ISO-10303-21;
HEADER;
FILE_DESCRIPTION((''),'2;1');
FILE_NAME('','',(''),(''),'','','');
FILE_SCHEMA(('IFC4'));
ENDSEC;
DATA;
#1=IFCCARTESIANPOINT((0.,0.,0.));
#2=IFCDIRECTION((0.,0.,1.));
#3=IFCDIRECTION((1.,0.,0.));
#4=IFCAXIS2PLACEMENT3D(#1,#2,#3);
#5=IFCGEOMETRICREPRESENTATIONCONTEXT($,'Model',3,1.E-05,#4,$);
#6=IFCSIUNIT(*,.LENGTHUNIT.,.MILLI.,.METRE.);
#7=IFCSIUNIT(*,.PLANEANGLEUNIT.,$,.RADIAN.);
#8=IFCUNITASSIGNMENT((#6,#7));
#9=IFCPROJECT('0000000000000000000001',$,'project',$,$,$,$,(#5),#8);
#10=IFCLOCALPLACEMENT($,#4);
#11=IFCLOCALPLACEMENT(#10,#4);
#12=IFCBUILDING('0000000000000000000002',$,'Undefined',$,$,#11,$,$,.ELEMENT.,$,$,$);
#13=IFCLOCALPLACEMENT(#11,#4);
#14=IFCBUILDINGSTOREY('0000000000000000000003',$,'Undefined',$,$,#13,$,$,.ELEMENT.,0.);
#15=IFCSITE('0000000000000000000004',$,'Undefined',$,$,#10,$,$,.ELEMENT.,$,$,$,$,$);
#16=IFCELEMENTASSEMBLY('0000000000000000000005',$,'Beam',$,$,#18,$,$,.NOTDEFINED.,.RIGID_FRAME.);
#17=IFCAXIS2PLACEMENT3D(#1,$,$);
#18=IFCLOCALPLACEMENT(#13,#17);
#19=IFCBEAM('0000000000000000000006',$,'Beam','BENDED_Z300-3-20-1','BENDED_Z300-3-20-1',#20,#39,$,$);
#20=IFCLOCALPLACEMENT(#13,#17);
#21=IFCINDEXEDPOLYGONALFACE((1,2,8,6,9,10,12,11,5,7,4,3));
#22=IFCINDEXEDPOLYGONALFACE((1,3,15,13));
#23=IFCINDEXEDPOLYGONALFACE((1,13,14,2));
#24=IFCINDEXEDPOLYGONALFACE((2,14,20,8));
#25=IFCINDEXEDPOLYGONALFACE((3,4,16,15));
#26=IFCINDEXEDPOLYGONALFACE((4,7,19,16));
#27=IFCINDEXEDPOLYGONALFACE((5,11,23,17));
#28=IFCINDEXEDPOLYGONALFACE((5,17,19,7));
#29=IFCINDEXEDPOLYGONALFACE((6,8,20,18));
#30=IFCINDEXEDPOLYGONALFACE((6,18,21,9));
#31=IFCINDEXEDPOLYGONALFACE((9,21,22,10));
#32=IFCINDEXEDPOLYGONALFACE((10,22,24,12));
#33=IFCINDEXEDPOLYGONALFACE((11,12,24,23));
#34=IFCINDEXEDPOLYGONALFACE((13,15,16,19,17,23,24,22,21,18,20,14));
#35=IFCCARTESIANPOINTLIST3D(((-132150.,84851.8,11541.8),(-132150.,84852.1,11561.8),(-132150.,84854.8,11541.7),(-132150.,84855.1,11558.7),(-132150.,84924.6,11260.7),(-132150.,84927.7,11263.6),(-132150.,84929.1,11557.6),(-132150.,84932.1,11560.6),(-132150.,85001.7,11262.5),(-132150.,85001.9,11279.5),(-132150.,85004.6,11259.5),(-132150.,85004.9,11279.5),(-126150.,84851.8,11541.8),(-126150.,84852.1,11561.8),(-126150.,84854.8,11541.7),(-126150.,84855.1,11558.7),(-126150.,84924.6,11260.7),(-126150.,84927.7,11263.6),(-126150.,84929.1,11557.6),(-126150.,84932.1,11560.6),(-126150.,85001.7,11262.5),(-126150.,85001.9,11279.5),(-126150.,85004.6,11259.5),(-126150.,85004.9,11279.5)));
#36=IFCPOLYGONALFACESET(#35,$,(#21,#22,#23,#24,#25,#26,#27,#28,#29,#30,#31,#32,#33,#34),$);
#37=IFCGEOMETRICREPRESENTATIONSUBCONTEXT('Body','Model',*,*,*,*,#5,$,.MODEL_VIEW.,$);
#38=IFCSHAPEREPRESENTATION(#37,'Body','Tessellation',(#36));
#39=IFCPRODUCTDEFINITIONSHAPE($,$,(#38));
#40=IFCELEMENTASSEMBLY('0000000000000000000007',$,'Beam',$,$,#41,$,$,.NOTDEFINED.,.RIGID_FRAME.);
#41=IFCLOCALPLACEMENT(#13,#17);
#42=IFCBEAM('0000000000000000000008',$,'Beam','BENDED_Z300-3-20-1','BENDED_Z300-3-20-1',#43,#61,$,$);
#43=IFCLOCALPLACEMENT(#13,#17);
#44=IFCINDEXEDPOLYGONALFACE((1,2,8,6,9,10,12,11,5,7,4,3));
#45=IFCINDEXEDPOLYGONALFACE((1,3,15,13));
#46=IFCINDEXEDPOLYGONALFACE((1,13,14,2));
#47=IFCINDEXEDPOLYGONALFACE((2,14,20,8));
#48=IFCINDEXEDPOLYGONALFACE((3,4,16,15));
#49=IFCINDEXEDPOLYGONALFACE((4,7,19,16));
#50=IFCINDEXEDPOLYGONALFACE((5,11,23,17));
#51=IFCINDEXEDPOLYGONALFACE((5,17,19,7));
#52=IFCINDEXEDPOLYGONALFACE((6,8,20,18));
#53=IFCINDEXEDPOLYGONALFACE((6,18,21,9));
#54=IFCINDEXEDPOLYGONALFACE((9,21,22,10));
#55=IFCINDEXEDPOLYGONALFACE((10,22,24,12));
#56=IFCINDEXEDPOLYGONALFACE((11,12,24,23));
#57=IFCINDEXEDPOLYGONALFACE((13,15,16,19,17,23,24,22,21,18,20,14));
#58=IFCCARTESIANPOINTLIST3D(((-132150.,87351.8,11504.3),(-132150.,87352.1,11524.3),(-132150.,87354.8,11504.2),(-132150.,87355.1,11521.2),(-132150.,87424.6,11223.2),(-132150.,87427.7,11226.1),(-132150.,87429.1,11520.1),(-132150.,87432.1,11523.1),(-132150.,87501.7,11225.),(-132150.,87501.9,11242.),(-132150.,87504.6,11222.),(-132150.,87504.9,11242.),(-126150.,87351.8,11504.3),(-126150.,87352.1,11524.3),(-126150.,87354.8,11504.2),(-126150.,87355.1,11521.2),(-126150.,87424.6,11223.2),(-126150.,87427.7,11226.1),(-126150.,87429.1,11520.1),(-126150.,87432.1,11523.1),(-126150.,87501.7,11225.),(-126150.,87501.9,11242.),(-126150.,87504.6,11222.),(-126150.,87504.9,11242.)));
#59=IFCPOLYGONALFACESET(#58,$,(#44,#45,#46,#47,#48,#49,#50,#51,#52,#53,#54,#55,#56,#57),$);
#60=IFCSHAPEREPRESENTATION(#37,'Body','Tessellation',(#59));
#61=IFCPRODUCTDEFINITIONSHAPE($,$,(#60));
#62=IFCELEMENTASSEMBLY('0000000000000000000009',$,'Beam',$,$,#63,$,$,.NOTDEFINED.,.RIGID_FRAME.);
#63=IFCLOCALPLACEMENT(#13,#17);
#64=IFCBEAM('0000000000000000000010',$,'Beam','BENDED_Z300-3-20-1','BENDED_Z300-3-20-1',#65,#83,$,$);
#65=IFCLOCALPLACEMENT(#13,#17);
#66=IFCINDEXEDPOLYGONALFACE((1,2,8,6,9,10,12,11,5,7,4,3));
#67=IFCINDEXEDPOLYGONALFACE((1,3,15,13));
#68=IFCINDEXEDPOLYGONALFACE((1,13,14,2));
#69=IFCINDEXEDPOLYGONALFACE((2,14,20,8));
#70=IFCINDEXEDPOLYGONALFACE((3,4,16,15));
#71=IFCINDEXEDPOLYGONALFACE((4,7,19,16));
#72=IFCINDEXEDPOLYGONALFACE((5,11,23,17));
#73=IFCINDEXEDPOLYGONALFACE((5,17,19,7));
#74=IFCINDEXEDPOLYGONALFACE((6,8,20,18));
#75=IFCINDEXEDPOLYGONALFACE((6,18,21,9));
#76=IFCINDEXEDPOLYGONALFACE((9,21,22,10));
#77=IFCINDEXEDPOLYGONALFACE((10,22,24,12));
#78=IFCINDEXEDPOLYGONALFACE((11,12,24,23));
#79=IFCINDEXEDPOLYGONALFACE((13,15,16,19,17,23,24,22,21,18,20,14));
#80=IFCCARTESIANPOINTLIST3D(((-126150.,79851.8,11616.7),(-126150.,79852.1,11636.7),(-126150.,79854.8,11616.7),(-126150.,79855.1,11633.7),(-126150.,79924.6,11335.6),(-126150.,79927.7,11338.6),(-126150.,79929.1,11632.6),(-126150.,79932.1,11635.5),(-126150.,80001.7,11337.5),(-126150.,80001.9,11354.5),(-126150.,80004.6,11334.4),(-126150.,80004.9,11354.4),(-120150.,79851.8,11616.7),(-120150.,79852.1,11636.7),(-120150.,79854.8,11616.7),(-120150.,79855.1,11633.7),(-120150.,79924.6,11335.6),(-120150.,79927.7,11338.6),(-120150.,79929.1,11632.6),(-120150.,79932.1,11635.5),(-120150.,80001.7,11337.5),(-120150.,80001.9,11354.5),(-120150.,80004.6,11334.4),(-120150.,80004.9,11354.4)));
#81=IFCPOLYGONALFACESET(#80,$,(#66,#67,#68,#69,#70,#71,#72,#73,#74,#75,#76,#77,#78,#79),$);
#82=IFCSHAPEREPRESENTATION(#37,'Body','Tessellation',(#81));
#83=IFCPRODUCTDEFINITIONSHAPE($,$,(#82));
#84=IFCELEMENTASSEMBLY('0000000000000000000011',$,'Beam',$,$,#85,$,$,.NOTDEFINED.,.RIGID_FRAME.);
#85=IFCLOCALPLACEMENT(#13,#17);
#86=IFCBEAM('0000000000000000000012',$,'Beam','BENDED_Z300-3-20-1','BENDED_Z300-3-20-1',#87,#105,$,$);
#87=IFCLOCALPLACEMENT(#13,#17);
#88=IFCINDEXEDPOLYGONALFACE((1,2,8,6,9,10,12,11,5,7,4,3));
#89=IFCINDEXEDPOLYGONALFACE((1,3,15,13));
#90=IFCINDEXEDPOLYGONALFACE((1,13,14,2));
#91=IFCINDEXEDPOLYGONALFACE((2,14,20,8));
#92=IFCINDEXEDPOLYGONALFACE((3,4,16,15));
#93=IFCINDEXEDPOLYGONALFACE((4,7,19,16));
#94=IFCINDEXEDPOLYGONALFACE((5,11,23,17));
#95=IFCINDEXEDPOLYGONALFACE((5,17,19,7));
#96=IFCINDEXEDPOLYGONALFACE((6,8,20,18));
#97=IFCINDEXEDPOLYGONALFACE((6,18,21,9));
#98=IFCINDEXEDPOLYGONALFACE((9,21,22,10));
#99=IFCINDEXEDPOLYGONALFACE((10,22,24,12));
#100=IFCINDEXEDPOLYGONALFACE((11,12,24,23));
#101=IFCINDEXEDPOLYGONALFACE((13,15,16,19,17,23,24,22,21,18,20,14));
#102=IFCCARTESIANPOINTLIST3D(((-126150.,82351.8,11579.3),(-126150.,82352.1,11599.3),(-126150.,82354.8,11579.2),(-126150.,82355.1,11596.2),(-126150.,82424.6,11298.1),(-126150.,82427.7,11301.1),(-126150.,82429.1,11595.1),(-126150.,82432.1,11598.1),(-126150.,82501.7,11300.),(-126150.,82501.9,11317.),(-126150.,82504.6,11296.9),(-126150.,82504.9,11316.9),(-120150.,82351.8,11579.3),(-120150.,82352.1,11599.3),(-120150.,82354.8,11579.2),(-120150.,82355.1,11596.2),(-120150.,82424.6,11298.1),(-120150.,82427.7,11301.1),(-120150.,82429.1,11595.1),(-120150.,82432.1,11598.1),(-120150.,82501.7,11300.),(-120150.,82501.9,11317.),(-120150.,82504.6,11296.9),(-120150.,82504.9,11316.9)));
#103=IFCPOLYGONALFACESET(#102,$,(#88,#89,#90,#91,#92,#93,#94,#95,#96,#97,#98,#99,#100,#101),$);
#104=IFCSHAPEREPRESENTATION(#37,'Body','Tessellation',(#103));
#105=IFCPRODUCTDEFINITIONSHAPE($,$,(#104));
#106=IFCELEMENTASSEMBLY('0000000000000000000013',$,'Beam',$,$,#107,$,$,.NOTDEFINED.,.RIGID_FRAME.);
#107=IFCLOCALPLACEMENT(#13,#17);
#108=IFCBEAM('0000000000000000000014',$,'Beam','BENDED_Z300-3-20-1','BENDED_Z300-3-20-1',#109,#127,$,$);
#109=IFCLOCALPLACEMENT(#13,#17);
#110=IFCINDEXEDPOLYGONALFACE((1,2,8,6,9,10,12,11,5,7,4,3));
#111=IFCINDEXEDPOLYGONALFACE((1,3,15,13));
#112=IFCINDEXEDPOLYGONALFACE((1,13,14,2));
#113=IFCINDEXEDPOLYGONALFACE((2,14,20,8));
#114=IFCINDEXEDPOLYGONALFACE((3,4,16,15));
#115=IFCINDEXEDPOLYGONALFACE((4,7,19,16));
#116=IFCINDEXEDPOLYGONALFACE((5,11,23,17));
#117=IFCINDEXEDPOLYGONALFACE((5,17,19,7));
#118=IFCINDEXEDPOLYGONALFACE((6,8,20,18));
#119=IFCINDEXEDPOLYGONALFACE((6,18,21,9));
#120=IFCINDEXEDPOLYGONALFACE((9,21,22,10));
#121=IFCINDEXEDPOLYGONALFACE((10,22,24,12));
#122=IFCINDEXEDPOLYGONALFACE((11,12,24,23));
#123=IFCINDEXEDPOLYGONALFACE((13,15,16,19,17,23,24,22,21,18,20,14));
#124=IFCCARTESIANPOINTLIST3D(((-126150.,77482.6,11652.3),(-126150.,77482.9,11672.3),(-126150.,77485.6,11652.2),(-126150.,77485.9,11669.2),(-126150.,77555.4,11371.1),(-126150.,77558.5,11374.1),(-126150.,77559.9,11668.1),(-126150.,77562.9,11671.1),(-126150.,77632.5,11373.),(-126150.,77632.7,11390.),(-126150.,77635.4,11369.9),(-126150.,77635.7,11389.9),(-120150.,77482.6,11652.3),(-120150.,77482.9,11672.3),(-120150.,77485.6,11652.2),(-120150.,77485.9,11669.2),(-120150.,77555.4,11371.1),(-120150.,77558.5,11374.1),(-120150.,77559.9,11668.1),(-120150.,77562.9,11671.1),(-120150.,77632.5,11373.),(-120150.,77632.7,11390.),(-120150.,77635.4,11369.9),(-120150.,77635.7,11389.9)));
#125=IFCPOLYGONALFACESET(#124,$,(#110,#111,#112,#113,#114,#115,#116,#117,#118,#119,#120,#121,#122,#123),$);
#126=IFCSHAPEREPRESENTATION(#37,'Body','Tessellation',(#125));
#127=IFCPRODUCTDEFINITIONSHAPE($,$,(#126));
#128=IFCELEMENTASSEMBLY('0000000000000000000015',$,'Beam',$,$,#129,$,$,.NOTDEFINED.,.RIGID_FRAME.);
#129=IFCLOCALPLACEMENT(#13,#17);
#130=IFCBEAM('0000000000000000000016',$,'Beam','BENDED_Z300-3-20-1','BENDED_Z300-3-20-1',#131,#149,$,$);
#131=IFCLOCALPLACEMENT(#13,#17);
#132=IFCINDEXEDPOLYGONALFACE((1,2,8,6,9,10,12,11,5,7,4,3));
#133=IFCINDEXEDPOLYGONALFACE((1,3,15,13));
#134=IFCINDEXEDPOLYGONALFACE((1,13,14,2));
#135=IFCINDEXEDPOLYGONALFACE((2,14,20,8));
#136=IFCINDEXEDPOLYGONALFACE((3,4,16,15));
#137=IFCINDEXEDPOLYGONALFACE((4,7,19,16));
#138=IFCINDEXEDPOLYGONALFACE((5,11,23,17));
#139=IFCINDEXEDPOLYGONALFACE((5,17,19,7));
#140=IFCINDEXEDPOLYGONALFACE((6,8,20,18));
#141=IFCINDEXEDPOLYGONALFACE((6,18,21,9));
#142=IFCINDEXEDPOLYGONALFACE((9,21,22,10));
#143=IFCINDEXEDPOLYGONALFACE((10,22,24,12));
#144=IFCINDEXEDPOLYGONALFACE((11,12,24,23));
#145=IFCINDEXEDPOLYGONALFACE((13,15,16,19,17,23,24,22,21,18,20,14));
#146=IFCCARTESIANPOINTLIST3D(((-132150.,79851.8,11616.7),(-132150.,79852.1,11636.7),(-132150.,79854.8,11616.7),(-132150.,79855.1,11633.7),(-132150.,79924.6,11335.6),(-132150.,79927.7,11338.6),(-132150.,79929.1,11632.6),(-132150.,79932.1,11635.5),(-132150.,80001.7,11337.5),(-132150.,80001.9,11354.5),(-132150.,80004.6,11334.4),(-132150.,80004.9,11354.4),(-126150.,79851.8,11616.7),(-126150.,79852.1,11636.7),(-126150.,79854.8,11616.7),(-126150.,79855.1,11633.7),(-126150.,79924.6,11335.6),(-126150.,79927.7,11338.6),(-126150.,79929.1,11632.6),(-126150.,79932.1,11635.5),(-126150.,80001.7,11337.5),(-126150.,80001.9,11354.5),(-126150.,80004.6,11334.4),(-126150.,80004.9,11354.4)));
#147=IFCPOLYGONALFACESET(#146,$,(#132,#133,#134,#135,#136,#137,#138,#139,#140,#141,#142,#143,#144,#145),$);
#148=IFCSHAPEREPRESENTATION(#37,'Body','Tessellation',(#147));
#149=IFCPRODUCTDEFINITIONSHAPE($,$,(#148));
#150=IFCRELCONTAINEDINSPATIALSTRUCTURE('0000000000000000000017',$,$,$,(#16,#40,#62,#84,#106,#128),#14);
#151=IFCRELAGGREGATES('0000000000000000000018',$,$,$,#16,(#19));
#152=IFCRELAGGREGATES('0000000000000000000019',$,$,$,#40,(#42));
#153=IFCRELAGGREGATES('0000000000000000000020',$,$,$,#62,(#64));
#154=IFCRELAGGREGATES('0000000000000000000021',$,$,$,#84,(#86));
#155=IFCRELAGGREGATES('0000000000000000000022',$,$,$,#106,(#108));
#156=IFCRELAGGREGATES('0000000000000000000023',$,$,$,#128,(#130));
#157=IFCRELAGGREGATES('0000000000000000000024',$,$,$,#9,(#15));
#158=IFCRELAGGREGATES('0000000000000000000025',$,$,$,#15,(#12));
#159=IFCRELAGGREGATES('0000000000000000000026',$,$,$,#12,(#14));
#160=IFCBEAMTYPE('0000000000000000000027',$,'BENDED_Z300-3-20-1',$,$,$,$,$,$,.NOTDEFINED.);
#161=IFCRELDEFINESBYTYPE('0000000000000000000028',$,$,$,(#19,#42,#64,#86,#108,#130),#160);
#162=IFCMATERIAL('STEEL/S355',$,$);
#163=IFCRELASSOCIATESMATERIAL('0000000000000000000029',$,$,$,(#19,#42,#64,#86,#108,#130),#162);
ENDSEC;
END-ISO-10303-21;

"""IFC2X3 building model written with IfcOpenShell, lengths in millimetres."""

from ifc_helpers import new_model, si_unit, frame, origin_with_axes, place, context, subcontext, project, spatial, polyline, outline, extrude, material, type_object, element, aggregate, save


model = new_model("IFC2X3")

# Units and contexts
model_context = context("Model", 3, precision=1e-05, world=origin_with_axes())
body_context = subcontext(model_context, "Body", "Model", "MODEL_VIEW")
ifc_project = project(units=[si_unit("LENGTHUNIT", "METRE", prefix="MILLI"), si_unit("PLANEANGLEUNIT", "RADIAN")], contexts=[model_context])

# Site, building, storey
site_placement = place(None, origin_with_axes())
site = spatial("IfcSite", under=ifc_project, at=site_placement, Name="Undefined", CompositionType="ELEMENT")
building_placement = place(site_placement, origin_with_axes())
building = spatial("IfcBuilding", under=site, at=building_placement, Name="Undefined", CompositionType="ELEMENT")
storey_placement = place(building_placement, origin_with_axes())
storey = spatial("IfcBuildingStorey", under=building, at=storey_placement, Name="Undefined", CompositionType="ELEMENT", Elevation=0.0)

# Element assemblies, beams
ifc_material_1 = material(Name="STEEL/S355")
beam_type_1 = type_object("IfcBeamType", Name="BENDED_Z300-3-20-1", PredefinedType="NOTDEFINED")
assembly_1_placement = place(storey_placement, origin_with_axes())
assembly_1 = element("IfcElementAssembly", 1, at=assembly_1_placement, inside=storey, Name="Beam", AssemblyPlace="NOTDEFINED", PredefinedType="RIGID_FRAME")
beam_1_placement = place(assembly_1_placement, frame((-132150.0, 84928.4, 11410.6), z_axis=(0.0, 0.014963, 0.999888), x_axis=(1.0, 0.0, 0.0)))
beam_1 = element("IfcBeam", 2, at=beam_1_placement, type_object=beam_type_1, material=ifc_material_1, Name="Beam", Description="BENDED_Z300-3-20-1", ObjectType="BENDED_Z300-3-20-1", context=body_context, shape_type="SweptSolid", body=[
    extrude(outline(polyline([(1.5, -150.0), (-78.5, -150.0), (-78.5, -130.0), (-75.5, -130.0), (-75.5, -147.0), (-1.5, -147.0), (-1.5, 150.0), (78.5, 150.0), (78.5, 130.0), (75.5, 130.0), (75.5, 147.0), (1.5, 147.0), (1.5, -150.0)])), frame((6000.0, 0.0, 0.0), z_axis=(-1.0, 0.0, 0.0), x_axis=(0.0, -1.0, 0.0)), (0.0, 0.0, 1.0), 6000.0),
])
aggregate(assembly_1, [beam_1])
assembly_2_placement = place(storey_placement, origin_with_axes())
assembly_2 = element("IfcElementAssembly", 3, at=assembly_2_placement, inside=storey, Name="Beam", AssemblyPlace="NOTDEFINED", PredefinedType="RIGID_FRAME")
beam_2_placement = place(assembly_2_placement, frame((-132150.0, 87428.4, 11373.1), z_axis=(0.0, 0.014963, 0.999888), x_axis=(1.0, 0.0, 0.0)))
beam_2 = element("IfcBeam", 4, at=beam_2_placement, type_object=beam_type_1, material=ifc_material_1, Name="Beam", Description="BENDED_Z300-3-20-1", ObjectType="BENDED_Z300-3-20-1", context=body_context, shape_type="SweptSolid", body=[
    extrude(outline(polyline([(1.5, -150.0), (-78.5, -150.0), (-78.5, -130.0), (-75.5, -130.0), (-75.5, -147.0), (-1.5, -147.0), (-1.5, 150.0), (78.5, 150.0), (78.5, 130.0), (75.5, 130.0), (75.5, 147.0), (1.5, 147.0), (1.5, -150.0)])), frame((6000.0, 0.0, 0.0), z_axis=(-1.0, 0.0, 0.0), x_axis=(0.0, -1.0, 0.0)), (0.0, 0.0, 1.0), 6000.0),
])
aggregate(assembly_2, [beam_2])
assembly_3_placement = place(storey_placement, origin_with_axes())
assembly_3 = element("IfcElementAssembly", 5, at=assembly_3_placement, inside=storey, Name="Beam", AssemblyPlace="NOTDEFINED", PredefinedType="RIGID_FRAME")
beam_3_placement = place(assembly_3_placement, frame((-126150.0, 79928.4, 11485.6), z_axis=(0.0, 0.014963, 0.999888), x_axis=(1.0, 0.0, 0.0)))
beam_3 = element("IfcBeam", 6, at=beam_3_placement, type_object=beam_type_1, material=ifc_material_1, Name="Beam", Description="BENDED_Z300-3-20-1", ObjectType="BENDED_Z300-3-20-1", context=body_context, shape_type="SweptSolid", body=[
    extrude(outline(polyline([(1.5, -150.0), (-78.5, -150.0), (-78.5, -130.0), (-75.5, -130.0), (-75.5, -147.0), (-1.5, -147.0), (-1.5, 150.0), (78.5, 150.0), (78.5, 130.0), (75.5, 130.0), (75.5, 147.0), (1.5, 147.0), (1.5, -150.0)])), frame((6000.0, 0.0, 0.0), z_axis=(-1.0, 0.0, 0.0), x_axis=(0.0, -1.0, 0.0)), (0.0, 0.0, 1.0), 6000.0),
])
aggregate(assembly_3, [beam_3])
assembly_4_placement = place(storey_placement, origin_with_axes())
assembly_4 = element("IfcElementAssembly", 7, at=assembly_4_placement, inside=storey, Name="Beam", AssemblyPlace="NOTDEFINED", PredefinedType="RIGID_FRAME")
beam_4_placement = place(assembly_4_placement, frame((-126150.0, 82428.4, 11448.1), z_axis=(0.0, 0.014963, 0.999888), x_axis=(1.0, 0.0, 0.0)))
beam_4 = element("IfcBeam", 8, at=beam_4_placement, type_object=beam_type_1, material=ifc_material_1, Name="Beam", Description="BENDED_Z300-3-20-1", ObjectType="BENDED_Z300-3-20-1", context=body_context, shape_type="SweptSolid", body=[
    extrude(outline(polyline([(1.5, -150.0), (-78.5, -150.0), (-78.5, -130.0), (-75.5, -130.0), (-75.5, -147.0), (-1.5, -147.0), (-1.5, 150.0), (78.5, 150.0), (78.5, 130.0), (75.5, 130.0), (75.5, 147.0), (1.5, 147.0), (1.5, -150.0)])), frame((6000.0, 0.0, 0.0), z_axis=(-1.0, 0.0, 0.0), x_axis=(0.0, -1.0, 0.0)), (0.0, 0.0, 1.0), 6000.0),
])
aggregate(assembly_4, [beam_4])
assembly_5_placement = place(storey_placement, origin_with_axes())
assembly_5 = element("IfcElementAssembly", 9, at=assembly_5_placement, inside=storey, Name="Beam", AssemblyPlace="NOTDEFINED", PredefinedType="RIGID_FRAME")
beam_5_placement = place(assembly_5_placement, frame((-126150.0, 77559.2, 11521.1), z_axis=(0.0, 0.014963, 0.999888), x_axis=(1.0, 0.0, 0.0)))
beam_5 = element("IfcBeam", 10, at=beam_5_placement, type_object=beam_type_1, material=ifc_material_1, Name="Beam", Description="BENDED_Z300-3-20-1", ObjectType="BENDED_Z300-3-20-1", context=body_context, shape_type="SweptSolid", body=[
    extrude(outline(polyline([(1.5, -150.0), (-78.5, -150.0), (-78.5, -130.0), (-75.5, -130.0), (-75.5, -147.0), (-1.5, -147.0), (-1.5, 150.0), (78.5, 150.0), (78.5, 130.0), (75.5, 130.0), (75.5, 147.0), (1.5, 147.0), (1.5, -150.0)])), frame((6000.0, 0.0, 0.0), z_axis=(-1.0, 0.0, 0.0), x_axis=(0.0, -1.0, 0.0)), (0.0, 0.0, 1.0), 6000.0),
])
aggregate(assembly_5, [beam_5])
assembly_6_placement = place(storey_placement, origin_with_axes())
assembly_6 = element("IfcElementAssembly", 11, at=assembly_6_placement, inside=storey, Name="Beam", AssemblyPlace="NOTDEFINED", PredefinedType="RIGID_FRAME")
beam_6_placement = place(assembly_6_placement, frame((-132150.0, 79928.4, 11485.6), z_axis=(0.0, 0.014963, 0.999888), x_axis=(1.0, 0.0, 0.0)))
beam_6 = element("IfcBeam", 12, at=beam_6_placement, type_object=beam_type_1, material=ifc_material_1, Name="Beam", Description="BENDED_Z300-3-20-1", ObjectType="BENDED_Z300-3-20-1", context=body_context, shape_type="SweptSolid", body=[
    extrude(outline(polyline([(1.5, -150.0), (-78.5, -150.0), (-78.5, -130.0), (-75.5, -130.0), (-75.5, -147.0), (-1.5, -147.0), (-1.5, 150.0), (78.5, 150.0), (78.5, 130.0), (75.5, 130.0), (75.5, 147.0), (1.5, 147.0), (1.5, -150.0)])), frame((6000.0, 0.0, 0.0), z_axis=(-1.0, 0.0, 0.0), x_axis=(0.0, -1.0, 0.0)), (0.0, 0.0, 1.0), 6000.0),
])
aggregate(assembly_6, [beam_6])

save(model, "model.ifc")
